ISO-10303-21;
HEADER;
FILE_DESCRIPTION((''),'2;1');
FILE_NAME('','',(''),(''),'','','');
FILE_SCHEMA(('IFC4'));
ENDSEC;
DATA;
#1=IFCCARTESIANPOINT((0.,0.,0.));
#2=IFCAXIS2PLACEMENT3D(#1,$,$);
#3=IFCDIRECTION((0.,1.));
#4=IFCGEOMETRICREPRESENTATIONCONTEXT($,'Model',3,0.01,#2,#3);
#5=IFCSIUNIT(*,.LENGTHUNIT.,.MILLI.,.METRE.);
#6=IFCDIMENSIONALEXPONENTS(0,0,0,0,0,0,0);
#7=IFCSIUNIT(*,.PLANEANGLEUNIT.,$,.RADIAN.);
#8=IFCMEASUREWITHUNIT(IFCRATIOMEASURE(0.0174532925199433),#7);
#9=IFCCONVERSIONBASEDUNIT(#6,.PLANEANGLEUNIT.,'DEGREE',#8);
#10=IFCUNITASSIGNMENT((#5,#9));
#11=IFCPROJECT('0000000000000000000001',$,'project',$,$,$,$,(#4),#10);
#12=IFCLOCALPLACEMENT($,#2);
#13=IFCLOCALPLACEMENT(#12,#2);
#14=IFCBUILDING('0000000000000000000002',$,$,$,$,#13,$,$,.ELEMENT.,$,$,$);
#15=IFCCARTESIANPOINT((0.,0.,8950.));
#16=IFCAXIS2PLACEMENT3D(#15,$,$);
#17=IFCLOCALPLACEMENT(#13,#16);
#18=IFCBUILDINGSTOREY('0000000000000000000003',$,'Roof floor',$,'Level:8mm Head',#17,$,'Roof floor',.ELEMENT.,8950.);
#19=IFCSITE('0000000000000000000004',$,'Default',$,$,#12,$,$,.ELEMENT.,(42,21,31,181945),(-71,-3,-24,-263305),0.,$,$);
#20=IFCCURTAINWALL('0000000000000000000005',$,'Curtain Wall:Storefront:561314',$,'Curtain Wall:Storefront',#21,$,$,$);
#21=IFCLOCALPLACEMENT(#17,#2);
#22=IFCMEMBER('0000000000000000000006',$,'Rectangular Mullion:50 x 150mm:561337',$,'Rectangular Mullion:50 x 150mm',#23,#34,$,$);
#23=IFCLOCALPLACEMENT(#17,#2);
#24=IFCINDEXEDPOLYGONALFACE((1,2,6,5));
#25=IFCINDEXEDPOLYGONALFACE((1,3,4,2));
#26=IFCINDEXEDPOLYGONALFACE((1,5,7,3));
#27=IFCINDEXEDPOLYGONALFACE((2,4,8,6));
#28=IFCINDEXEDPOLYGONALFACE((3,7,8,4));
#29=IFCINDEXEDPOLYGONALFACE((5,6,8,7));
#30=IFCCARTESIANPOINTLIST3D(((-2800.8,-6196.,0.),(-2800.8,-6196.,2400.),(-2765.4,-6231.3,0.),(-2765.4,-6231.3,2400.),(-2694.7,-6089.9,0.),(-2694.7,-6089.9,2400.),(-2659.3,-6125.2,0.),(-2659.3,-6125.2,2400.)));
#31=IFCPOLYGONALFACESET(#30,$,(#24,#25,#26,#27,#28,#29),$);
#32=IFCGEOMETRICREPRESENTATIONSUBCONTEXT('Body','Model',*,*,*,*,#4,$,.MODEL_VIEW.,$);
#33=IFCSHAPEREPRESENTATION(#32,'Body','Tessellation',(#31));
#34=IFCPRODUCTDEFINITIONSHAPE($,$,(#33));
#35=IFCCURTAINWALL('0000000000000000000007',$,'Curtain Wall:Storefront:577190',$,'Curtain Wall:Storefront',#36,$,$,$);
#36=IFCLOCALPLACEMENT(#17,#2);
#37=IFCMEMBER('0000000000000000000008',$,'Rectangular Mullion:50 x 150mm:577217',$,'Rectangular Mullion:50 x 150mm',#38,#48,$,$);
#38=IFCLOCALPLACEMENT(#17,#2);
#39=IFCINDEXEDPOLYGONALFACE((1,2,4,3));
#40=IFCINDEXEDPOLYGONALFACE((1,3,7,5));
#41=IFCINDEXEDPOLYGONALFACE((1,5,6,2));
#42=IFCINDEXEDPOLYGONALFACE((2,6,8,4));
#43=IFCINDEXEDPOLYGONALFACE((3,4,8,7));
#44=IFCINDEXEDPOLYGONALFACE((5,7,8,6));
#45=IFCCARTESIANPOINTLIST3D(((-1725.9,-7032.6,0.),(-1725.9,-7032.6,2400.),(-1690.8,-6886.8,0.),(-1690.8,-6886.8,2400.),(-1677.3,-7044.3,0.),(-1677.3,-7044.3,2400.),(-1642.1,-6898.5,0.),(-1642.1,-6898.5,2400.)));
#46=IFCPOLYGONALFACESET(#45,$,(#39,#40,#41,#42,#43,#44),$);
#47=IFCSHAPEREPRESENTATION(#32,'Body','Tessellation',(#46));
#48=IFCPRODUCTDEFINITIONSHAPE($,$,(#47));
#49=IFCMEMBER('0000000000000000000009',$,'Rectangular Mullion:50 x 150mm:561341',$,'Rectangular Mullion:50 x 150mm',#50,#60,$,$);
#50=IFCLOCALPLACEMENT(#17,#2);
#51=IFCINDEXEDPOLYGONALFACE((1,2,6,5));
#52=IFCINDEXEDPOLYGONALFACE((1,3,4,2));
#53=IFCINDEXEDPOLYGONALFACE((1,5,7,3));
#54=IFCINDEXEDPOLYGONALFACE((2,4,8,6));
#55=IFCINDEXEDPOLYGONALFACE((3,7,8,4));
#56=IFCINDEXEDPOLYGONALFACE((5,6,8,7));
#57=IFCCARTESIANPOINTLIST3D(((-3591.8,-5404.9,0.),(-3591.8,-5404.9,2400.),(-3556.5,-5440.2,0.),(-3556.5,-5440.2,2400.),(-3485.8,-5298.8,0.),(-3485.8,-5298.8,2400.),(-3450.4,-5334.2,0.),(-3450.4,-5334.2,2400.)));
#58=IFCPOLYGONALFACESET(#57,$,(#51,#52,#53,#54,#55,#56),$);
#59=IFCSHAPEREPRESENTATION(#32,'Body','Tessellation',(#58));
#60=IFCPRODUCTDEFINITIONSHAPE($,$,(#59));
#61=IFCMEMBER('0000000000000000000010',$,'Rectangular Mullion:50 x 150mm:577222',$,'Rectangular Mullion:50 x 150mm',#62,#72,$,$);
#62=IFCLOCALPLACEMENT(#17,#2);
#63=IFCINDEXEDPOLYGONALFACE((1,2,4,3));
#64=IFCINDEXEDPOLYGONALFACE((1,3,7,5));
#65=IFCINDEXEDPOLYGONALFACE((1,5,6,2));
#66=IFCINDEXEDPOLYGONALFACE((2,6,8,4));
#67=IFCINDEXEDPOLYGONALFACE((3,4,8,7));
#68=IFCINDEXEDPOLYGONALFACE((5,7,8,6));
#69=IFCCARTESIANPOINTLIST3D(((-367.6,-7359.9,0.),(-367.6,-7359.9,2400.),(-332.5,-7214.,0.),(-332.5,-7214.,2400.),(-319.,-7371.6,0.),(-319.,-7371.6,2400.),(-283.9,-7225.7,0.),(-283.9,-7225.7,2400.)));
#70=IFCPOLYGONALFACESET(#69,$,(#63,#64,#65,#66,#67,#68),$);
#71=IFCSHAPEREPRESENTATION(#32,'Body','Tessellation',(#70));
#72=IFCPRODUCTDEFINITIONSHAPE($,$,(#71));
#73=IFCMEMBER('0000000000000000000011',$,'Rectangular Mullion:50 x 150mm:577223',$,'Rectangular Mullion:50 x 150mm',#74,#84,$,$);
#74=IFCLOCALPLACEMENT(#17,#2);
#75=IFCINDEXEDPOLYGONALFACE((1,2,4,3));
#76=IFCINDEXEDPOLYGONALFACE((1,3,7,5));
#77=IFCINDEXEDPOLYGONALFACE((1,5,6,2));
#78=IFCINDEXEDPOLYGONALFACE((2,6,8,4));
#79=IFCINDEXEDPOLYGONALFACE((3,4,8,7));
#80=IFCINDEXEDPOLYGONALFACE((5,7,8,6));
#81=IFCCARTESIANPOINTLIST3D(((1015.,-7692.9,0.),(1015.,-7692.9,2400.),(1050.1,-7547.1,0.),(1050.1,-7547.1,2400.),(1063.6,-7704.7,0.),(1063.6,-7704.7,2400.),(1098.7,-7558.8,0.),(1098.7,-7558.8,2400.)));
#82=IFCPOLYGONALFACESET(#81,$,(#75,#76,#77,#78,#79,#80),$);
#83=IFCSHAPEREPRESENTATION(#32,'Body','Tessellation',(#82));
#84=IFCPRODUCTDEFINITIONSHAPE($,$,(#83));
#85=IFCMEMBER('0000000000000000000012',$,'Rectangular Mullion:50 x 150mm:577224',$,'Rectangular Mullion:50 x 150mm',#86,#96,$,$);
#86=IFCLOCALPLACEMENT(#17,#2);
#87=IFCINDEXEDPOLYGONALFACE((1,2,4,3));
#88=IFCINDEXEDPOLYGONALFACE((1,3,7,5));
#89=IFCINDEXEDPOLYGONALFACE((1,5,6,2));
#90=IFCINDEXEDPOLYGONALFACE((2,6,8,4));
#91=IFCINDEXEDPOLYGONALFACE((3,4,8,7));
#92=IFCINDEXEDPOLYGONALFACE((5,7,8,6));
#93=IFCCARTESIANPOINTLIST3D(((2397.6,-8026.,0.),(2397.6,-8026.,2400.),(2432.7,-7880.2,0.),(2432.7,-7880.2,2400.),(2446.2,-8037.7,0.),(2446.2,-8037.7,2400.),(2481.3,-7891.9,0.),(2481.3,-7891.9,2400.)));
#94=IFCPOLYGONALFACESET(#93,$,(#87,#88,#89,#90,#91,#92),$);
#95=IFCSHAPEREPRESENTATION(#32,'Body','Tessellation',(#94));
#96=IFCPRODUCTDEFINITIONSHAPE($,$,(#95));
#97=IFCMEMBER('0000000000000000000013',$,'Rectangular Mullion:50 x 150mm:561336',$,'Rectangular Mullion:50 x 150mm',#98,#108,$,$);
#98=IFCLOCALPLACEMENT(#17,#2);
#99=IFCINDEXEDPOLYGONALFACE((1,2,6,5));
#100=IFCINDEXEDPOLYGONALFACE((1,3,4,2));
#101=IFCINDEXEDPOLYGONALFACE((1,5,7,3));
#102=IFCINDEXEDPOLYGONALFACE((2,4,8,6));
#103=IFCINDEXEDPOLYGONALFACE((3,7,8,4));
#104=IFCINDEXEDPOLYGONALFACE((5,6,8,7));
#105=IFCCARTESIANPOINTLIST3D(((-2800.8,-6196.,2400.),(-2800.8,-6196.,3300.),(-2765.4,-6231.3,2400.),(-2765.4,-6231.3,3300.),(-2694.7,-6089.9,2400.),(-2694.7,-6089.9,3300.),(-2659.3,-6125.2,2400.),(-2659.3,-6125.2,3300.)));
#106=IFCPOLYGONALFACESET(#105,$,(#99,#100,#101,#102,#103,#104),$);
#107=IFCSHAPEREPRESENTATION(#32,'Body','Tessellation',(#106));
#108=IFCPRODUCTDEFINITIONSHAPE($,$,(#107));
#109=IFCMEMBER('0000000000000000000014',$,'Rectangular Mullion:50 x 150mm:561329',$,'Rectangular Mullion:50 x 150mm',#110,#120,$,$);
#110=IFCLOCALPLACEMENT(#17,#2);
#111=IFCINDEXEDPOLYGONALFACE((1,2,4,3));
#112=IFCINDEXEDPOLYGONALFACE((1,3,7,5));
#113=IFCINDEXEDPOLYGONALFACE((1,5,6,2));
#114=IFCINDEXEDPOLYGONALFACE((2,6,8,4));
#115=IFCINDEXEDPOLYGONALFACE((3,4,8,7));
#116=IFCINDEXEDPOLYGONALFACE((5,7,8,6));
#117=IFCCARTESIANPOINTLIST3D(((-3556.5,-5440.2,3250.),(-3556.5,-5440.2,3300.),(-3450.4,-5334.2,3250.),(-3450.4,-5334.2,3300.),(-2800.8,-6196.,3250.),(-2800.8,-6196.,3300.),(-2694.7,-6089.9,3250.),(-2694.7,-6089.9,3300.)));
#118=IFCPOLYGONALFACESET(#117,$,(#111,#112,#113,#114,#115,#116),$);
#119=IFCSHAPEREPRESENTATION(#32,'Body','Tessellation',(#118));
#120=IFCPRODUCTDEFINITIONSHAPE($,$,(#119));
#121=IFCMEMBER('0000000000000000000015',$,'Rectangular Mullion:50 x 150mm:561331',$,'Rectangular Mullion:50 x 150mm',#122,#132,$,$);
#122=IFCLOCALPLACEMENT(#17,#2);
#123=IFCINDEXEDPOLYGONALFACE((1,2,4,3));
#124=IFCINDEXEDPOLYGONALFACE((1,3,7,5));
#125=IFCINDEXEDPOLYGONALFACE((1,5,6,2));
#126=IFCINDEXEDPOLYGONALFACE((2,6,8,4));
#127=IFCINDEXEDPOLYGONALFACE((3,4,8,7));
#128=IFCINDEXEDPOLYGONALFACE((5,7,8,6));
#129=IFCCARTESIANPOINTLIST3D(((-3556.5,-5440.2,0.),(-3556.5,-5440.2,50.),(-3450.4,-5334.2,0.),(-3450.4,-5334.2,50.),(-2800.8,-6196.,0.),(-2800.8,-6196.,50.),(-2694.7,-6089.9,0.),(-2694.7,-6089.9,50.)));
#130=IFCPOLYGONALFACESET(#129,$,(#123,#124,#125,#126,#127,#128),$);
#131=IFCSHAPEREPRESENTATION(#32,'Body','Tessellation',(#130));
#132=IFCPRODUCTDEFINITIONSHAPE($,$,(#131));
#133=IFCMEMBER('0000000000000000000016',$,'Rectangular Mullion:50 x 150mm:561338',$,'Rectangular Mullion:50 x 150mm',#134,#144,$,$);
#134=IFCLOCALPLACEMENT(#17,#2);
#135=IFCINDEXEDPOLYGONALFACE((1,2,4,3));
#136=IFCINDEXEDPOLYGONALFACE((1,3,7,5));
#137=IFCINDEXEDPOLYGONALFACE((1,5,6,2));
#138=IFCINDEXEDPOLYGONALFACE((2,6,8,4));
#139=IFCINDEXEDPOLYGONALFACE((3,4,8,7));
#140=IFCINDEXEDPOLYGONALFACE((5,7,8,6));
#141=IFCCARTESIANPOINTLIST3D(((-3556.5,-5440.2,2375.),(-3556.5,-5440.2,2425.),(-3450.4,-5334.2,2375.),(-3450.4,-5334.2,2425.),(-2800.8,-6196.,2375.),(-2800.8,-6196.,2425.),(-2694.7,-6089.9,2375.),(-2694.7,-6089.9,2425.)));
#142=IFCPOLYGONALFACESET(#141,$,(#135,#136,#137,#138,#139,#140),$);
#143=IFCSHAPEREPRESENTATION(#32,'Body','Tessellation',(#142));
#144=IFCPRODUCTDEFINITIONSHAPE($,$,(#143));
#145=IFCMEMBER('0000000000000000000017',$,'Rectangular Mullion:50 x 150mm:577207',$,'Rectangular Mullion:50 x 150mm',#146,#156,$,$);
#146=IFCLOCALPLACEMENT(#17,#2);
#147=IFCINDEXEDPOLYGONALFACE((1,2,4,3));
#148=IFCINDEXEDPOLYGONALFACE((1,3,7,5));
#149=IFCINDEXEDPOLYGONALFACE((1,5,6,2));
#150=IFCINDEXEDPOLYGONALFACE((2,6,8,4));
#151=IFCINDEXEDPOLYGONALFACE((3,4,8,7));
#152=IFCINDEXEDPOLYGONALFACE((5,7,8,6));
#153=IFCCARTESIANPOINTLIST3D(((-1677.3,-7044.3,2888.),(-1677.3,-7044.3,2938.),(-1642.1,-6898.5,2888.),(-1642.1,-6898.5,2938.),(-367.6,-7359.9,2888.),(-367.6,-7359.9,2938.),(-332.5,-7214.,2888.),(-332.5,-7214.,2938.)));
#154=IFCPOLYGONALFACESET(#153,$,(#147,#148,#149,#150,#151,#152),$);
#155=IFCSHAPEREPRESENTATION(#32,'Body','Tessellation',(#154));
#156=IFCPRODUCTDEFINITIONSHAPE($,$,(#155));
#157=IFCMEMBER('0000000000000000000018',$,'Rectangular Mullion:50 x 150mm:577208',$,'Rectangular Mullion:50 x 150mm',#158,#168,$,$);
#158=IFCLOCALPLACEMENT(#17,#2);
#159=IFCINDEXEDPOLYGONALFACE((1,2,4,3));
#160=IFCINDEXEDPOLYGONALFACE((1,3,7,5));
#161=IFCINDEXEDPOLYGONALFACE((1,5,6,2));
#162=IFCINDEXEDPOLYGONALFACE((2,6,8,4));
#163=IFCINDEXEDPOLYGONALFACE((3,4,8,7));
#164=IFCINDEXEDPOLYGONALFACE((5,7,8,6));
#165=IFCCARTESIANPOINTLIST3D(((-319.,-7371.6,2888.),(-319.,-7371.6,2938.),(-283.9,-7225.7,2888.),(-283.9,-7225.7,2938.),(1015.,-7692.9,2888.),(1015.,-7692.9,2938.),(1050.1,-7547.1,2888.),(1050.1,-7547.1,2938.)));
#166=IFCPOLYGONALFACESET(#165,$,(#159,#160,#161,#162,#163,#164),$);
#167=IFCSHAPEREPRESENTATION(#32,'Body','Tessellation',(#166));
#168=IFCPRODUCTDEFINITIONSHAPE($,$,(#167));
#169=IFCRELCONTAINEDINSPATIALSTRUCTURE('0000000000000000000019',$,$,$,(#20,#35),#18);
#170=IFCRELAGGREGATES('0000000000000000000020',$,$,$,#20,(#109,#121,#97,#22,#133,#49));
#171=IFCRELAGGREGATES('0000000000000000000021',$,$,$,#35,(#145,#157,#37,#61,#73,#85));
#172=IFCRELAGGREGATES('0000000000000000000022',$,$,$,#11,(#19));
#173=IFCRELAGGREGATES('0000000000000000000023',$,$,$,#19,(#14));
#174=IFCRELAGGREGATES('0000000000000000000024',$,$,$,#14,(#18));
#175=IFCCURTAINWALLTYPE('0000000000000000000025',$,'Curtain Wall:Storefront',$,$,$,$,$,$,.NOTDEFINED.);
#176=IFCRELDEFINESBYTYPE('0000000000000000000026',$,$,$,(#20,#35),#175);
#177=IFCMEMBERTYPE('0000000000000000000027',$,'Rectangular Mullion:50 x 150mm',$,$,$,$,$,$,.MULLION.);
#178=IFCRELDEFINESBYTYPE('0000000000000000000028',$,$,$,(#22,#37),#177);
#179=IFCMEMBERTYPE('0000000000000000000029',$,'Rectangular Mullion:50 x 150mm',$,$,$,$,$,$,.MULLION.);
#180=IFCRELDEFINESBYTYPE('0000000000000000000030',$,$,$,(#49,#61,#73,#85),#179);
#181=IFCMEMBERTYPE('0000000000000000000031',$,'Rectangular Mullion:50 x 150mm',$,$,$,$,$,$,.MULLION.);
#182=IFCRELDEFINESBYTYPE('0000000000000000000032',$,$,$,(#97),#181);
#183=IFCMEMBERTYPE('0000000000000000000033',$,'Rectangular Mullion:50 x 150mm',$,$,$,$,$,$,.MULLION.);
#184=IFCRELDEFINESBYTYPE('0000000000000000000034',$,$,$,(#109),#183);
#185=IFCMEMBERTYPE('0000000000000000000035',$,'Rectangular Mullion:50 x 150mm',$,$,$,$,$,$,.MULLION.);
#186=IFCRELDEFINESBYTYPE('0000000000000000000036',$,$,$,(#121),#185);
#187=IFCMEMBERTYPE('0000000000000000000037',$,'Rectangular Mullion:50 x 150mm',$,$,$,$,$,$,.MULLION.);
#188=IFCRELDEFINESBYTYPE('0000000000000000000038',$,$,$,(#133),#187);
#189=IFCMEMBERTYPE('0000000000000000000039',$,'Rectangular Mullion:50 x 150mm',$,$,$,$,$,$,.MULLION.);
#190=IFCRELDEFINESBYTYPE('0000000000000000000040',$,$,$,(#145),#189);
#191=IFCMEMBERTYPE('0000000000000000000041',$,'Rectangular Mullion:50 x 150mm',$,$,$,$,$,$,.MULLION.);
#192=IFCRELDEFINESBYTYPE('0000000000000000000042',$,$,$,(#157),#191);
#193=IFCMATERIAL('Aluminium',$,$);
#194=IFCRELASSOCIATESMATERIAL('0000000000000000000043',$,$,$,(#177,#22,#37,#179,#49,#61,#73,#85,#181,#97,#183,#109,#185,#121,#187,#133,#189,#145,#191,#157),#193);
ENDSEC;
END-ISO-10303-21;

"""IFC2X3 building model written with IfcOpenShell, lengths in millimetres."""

from ifc_helpers import new_model, entity, si_unit, converted_unit, direction, frame, origin, origin_2d_with_axis, place, context, subcontext, project, spatial, rectangle, extrude, source, transform, mapped, material, type_object, type_shapes, element, aggregate, save


model = new_model("IFC2X3")

# Units and contexts
model_context = context("Model", 3, precision=0.01, world=origin(), true_north=direction((0.0, 1.0)))
body_context = subcontext(model_context, "Body", "Model", "MODEL_VIEW")
ifc_project = project(units=[si_unit("LENGTHUNIT", "METRE", prefix="MILLI"), converted_unit("PLANEANGLEUNIT", "DEGREE", entity("IfcRatioMeasure", 0.0174532925199433), si_unit("PLANEANGLEUNIT", "RADIAN"), dimensions=[0, 0, 0, 0, 0, 0, 0])], contexts=[model_context])

# Site, building, storey
site_placement = place(None, origin())
site = spatial("IfcSite", under=ifc_project, at=site_placement, Name="Default", CompositionType="ELEMENT", RefLatitude=(42, 21, 31, 181945), RefLongitude=(-71, -3, -24, -263305), RefElevation=0.0)
building_placement = place(site_placement, origin())
building = spatial("IfcBuilding", under=site, at=building_placement, CompositionType="ELEMENT")
storey_placement = place(building_placement, frame((0.0, 0.0, 8950.0)))
storey = spatial("IfcBuildingStorey", under=building, at=storey_placement, Name="Roof floor", ObjectType="Level:8mm Head", LongName="Roof floor", CompositionType="ELEMENT", Elevation=8950.0)

# Curtain walls, members
curtain_wall_type = type_object("IfcCurtainWallType", Name="Curtain Wall:Storefront", PredefinedType="NOTDEFINED")
curtain_wall_1_placement = place(storey_placement, frame((0.0, 0.0, -8950.0)))
curtain_wall_1 = element("IfcCurtainWall", 1, at=curtain_wall_1_placement, inside=storey, type_object=curtain_wall_type, Name="Curtain Wall:Storefront:561314", ObjectType="Curtain Wall:Storefront")
ifc_material_1 = material(Name="Aluminium")
member_type_1 = type_object("IfcMemberType", Name="Rectangular Mullion:50 x 150mm", PredefinedType="MULLION", material=ifc_material_1)
shared_shape_1 = source(origin(), body_context, "Body", "SweptSolid", [
    extrude(rectangle(XDim=150.0, YDim=50.0, at=origin_2d_with_axis()), frame((-25.0, 0.0, -2400.0), z_axis=(0.0, 0.0, 1.0), x_axis=(0.0, -1.0, 0.0)), (0.0, 0.0, 1.0), 2400.0),
])
type_shapes(member_type_1, [shared_shape_1])
member_1_placement = place(storey_placement, frame((-2712.4, -6178.3, 2400.0), z_axis=(0.0, 0.0, 1.0), x_axis=(0.707107, -0.707107, 0.0)))
member_1 = element("IfcMember", 2, at=member_1_placement, type_object=member_type_1, material=ifc_material_1, Name="Rectangular Mullion:50 x 150mm:561337", ObjectType="Rectangular Mullion:50 x 150mm", context=body_context, shape_type="MappedRepresentation", body=[
    mapped(shared_shape_1, transform((0.0, 0.0, 0.0), scale=1.0)),
])
curtain_wall_2_placement = place(storey_placement, frame((0.0, 0.0, -8950.0)))
curtain_wall_2 = element("IfcCurtainWall", 3, at=curtain_wall_2_placement, inside=storey, type_object=curtain_wall_type, Name="Curtain Wall:Storefront:577190", ObjectType="Curtain Wall:Storefront")
member_2_placement = place(storey_placement, frame((-1708.3, -6959.7, 2400.0), z_axis=(0.0, 0.0, 1.0), x_axis=(-0.972184, 0.234217, 0.0)))
member_2 = element("IfcMember", 4, at=member_2_placement, type_object=member_type_1, material=ifc_material_1, Name="Rectangular Mullion:50 x 150mm:577217", ObjectType="Rectangular Mullion:50 x 150mm", context=body_context, shape_type="MappedRepresentation", body=[
    mapped(shared_shape_1, transform((0.0, 0.0, 0.0), scale=1.0)),
])

# Members
member_type_2 = type_object("IfcMemberType", Name="Rectangular Mullion:50 x 150mm", PredefinedType="MULLION", material=ifc_material_1)
shared_shape_2 = source(origin(), body_context, "Body", "SweptSolid", [
    extrude(rectangle(XDim=150.0, YDim=50.0, at=origin_2d_with_axis()), frame((0.0, 0.0, -2400.0), z_axis=(0.0, 0.0, 1.0), x_axis=(0.0, -1.0, 0.0)), (0.0, 0.0, 1.0), 2400.0),
])
type_shapes(member_type_2, [shared_shape_2])
member_3_placement = place(storey_placement, frame((-3521.1, -5369.5, 0.0), z_axis=(0.0, 0.0, -1.0), x_axis=(-0.707107, 0.707107, 0.0)))
member_3 = element("IfcMember", 5, at=member_3_placement, type_object=member_type_2, material=ifc_material_1, Name="Rectangular Mullion:50 x 150mm:561341", ObjectType="Rectangular Mullion:50 x 150mm", context=body_context, shape_type="MappedRepresentation", body=[
    mapped(shared_shape_2, transform((0.0, 0.0, 0.0), scale=1.0)),
])
member_4_placement = place(storey_placement, frame((-325.7, -7292.8, 0.0), z_axis=(0.0, 0.0, -1.0), x_axis=(0.972184, -0.234217, 0.0)))
member_4 = element("IfcMember", 6, at=member_4_placement, type_object=member_type_2, material=ifc_material_1, Name="Rectangular Mullion:50 x 150mm:577222", ObjectType="Rectangular Mullion:50 x 150mm", context=body_context, shape_type="MappedRepresentation", body=[
    mapped(shared_shape_2, transform((0.0, 0.0, 0.0), scale=1.0)),
])
member_5_placement = place(storey_placement, frame((1056.8, -7625.9, 0.0), z_axis=(0.0, 0.0, -1.0), x_axis=(0.972184, -0.234217, 0.0)))
member_5 = element("IfcMember", 7, at=member_5_placement, type_object=member_type_2, material=ifc_material_1, Name="Rectangular Mullion:50 x 150mm:577223", ObjectType="Rectangular Mullion:50 x 150mm", context=body_context, shape_type="MappedRepresentation", body=[
    mapped(shared_shape_2, transform((0.0, 0.0, 0.0), scale=1.0)),
])
member_6_placement = place(storey_placement, frame((2439.4, -7959.0, 0.0), z_axis=(0.0, 0.0, -1.0), x_axis=(0.972184, -0.234217, 0.0)))
member_6 = element("IfcMember", 8, at=member_6_placement, type_object=member_type_2, material=ifc_material_1, Name="Rectangular Mullion:50 x 150mm:577224", ObjectType="Rectangular Mullion:50 x 150mm", context=body_context, shape_type="MappedRepresentation", body=[
    mapped(shared_shape_2, transform((0.0, 0.0, 0.0), scale=1.0)),
])
member_type_3 = type_object("IfcMemberType", Name="Rectangular Mullion:50 x 150mm", PredefinedType="MULLION", material=ifc_material_1)
shared_shape_3 = source(origin(), body_context, "Body", "SweptSolid", [
    extrude(rectangle(XDim=150.0, YDim=50.0, at=origin_2d_with_axis()), frame((-25.0, 0.0, -900.0), z_axis=(0.0, 0.0, 1.0), x_axis=(0.0, -1.0, 0.0)), (0.0, 0.0, 1.0), 900.0),
])
type_shapes(member_type_3, [shared_shape_3])
member_7_placement = place(storey_placement, frame((-2712.4, -6178.3, 3300.0), z_axis=(0.0, 0.0, 1.0), x_axis=(0.707107, -0.707107, 0.0)))
member_7 = element("IfcMember", 9, at=member_7_placement, type_object=member_type_3, material=ifc_material_1, Name="Rectangular Mullion:50 x 150mm:561336", ObjectType="Rectangular Mullion:50 x 150mm", context=body_context, shape_type="MappedRepresentation", body=[
    mapped(shared_shape_3, transform((0.0, 0.0, 0.0), scale=1.0)),
])
member_type_4 = type_object("IfcMemberType", Name="Rectangular Mullion:50 x 150mm", PredefinedType="MULLION", material=ifc_material_1)
shared_shape_4 = source(origin(), body_context, "Body", "SweptSolid", [
    extrude(rectangle(XDim=150.0, YDim=50.0, at=origin_2d_with_axis()), frame((-25.0, 0.0, -1068.7), z_axis=(0.0, 0.0, 1.0), x_axis=(0.0, -1.0, 0.0)), (0.0, 0.0, 1.0), 1068.7),
])
type_shapes(member_type_4, [shared_shape_4])
member_8_placement = place(storey_placement, frame((-3503.4, -5387.2, 3300.0), z_axis=(-0.707107, 0.707107, 0.0), x_axis=(0.0, 0.0, 1.0)))
member_8 = element("IfcMember", 10, at=member_8_placement, type_object=member_type_4, material=ifc_material_1, Name="Rectangular Mullion:50 x 150mm:561329", ObjectType="Rectangular Mullion:50 x 150mm", context=body_context, shape_type="MappedRepresentation", body=[
    mapped(shared_shape_4, transform((0.0, 0.0, 0.0), scale=1.0)),
])
member_type_5 = type_object("IfcMemberType", Name="Rectangular Mullion:50 x 150mm", PredefinedType="MULLION", material=ifc_material_1)
shared_shape_5 = source(origin(), body_context, "Body", "SweptSolid", [
    extrude(rectangle(XDim=150.0, YDim=50.0, at=origin_2d_with_axis()), frame((-25.0, 0.0, -1068.7), z_axis=(0.0, 0.0, 1.0), x_axis=(0.0, -1.0, 0.0)), (0.0, 0.0, 1.0), 1068.7),
])
type_shapes(member_type_5, [shared_shape_5])
member_9_placement = place(storey_placement, frame((-2747.7, -6142.9, 0.0), z_axis=(0.707107, -0.707107, 0.0), x_axis=(0.0, 0.0, -1.0)))
member_9 = element("IfcMember", 11, at=member_9_placement, type_object=member_type_5, material=ifc_material_1, Name="Rectangular Mullion:50 x 150mm:561331", ObjectType="Rectangular Mullion:50 x 150mm", context=body_context, shape_type="MappedRepresentation", body=[
    mapped(shared_shape_5, transform((0.0, 0.0, 0.0), scale=1.0)),
])
member_type_6 = type_object("IfcMemberType", Name="Rectangular Mullion:50 x 150mm", PredefinedType="MULLION", material=ifc_material_1)
shared_shape_6 = source(origin(), body_context, "Body", "SweptSolid", [
    extrude(rectangle(XDim=150.0, YDim=50.0, at=origin_2d_with_axis()), frame((0.0, 0.0, -1068.7), z_axis=(0.0, 0.0, 1.0), x_axis=(0.0, -1.0, 0.0)), (0.0, 0.0, 1.0), 1068.7),
])
type_shapes(member_type_6, [shared_shape_6])
member_10_placement = place(storey_placement, frame((-3503.4, -5387.2, 2400.0), z_axis=(-0.707107, 0.707107, 0.0), x_axis=(0.0, 0.0, 1.0)))
member_10 = element("IfcMember", 12, at=member_10_placement, type_object=member_type_6, material=ifc_material_1, Name="Rectangular Mullion:50 x 150mm:561338", ObjectType="Rectangular Mullion:50 x 150mm", context=body_context, shape_type="MappedRepresentation", body=[
    mapped(shared_shape_6, transform((0.0, 0.0, 0.0), scale=1.0)),
])
member_type_7 = type_object("IfcMemberType", Name="Rectangular Mullion:50 x 150mm", PredefinedType="MULLION", material=ifc_material_1)
shared_shape_7 = source(origin(), body_context, "Body", "SweptSolid", [
    extrude(rectangle(XDim=150.0, YDim=50.0, at=origin_2d_with_axis()), frame((-25.0, 0.0, -1347.1), z_axis=(0.0, 0.0, 1.0), x_axis=(0.0, -1.0, 0.0)), (0.0, 0.0, 1.0), 1347.1),
])
type_shapes(member_type_7, [shared_shape_7])
member_11_placement = place(storey_placement, frame((-350.0, -7286.9, 2938.0), z_axis=(0.972184, -0.234217, 0.0), x_axis=(0.0, 0.0, 1.0)))
member_11 = element("IfcMember", 13, at=member_11_placement, type_object=member_type_7, material=ifc_material_1, Name="Rectangular Mullion:50 x 150mm:577207", ObjectType="Rectangular Mullion:50 x 150mm", context=body_context, shape_type="MappedRepresentation", body=[
    mapped(shared_shape_7, transform((0.0, 0.0, 0.0), scale=1.0)),
])
member_type_8 = type_object("IfcMemberType", Name="Rectangular Mullion:50 x 150mm", PredefinedType="MULLION", material=ifc_material_1)
shared_shape_8 = source(origin(), body_context, "Body", "SweptSolid", [
    extrude(rectangle(XDim=150.0, YDim=50.0, at=origin_2d_with_axis()), frame((-25.0, 0.0, -1372.1), z_axis=(0.0, 0.0, 1.0), x_axis=(0.0, -1.0, 0.0)), (0.0, 0.0, 1.0), 1372.1),
])
type_shapes(member_type_8, [shared_shape_8])
member_12_placement = place(storey_placement, frame((1032.5, -7620.0, 2938.0), z_axis=(0.972184, -0.234217, 0.0), x_axis=(0.0, 0.0, 1.0)))
member_12 = element("IfcMember", 14, at=member_12_placement, type_object=member_type_8, material=ifc_material_1, Name="Rectangular Mullion:50 x 150mm:577208", ObjectType="Rectangular Mullion:50 x 150mm", context=body_context, shape_type="MappedRepresentation", body=[
    mapped(shared_shape_8, transform((0.0, 0.0, 0.0), scale=1.0)),
])

aggregate(curtain_wall_1, [member_8, member_9, member_7, member_1, member_10, member_3])
aggregate(curtain_wall_2, [member_11, member_12, member_2, member_4, member_5, member_6])

save(model, "model.ifc")
